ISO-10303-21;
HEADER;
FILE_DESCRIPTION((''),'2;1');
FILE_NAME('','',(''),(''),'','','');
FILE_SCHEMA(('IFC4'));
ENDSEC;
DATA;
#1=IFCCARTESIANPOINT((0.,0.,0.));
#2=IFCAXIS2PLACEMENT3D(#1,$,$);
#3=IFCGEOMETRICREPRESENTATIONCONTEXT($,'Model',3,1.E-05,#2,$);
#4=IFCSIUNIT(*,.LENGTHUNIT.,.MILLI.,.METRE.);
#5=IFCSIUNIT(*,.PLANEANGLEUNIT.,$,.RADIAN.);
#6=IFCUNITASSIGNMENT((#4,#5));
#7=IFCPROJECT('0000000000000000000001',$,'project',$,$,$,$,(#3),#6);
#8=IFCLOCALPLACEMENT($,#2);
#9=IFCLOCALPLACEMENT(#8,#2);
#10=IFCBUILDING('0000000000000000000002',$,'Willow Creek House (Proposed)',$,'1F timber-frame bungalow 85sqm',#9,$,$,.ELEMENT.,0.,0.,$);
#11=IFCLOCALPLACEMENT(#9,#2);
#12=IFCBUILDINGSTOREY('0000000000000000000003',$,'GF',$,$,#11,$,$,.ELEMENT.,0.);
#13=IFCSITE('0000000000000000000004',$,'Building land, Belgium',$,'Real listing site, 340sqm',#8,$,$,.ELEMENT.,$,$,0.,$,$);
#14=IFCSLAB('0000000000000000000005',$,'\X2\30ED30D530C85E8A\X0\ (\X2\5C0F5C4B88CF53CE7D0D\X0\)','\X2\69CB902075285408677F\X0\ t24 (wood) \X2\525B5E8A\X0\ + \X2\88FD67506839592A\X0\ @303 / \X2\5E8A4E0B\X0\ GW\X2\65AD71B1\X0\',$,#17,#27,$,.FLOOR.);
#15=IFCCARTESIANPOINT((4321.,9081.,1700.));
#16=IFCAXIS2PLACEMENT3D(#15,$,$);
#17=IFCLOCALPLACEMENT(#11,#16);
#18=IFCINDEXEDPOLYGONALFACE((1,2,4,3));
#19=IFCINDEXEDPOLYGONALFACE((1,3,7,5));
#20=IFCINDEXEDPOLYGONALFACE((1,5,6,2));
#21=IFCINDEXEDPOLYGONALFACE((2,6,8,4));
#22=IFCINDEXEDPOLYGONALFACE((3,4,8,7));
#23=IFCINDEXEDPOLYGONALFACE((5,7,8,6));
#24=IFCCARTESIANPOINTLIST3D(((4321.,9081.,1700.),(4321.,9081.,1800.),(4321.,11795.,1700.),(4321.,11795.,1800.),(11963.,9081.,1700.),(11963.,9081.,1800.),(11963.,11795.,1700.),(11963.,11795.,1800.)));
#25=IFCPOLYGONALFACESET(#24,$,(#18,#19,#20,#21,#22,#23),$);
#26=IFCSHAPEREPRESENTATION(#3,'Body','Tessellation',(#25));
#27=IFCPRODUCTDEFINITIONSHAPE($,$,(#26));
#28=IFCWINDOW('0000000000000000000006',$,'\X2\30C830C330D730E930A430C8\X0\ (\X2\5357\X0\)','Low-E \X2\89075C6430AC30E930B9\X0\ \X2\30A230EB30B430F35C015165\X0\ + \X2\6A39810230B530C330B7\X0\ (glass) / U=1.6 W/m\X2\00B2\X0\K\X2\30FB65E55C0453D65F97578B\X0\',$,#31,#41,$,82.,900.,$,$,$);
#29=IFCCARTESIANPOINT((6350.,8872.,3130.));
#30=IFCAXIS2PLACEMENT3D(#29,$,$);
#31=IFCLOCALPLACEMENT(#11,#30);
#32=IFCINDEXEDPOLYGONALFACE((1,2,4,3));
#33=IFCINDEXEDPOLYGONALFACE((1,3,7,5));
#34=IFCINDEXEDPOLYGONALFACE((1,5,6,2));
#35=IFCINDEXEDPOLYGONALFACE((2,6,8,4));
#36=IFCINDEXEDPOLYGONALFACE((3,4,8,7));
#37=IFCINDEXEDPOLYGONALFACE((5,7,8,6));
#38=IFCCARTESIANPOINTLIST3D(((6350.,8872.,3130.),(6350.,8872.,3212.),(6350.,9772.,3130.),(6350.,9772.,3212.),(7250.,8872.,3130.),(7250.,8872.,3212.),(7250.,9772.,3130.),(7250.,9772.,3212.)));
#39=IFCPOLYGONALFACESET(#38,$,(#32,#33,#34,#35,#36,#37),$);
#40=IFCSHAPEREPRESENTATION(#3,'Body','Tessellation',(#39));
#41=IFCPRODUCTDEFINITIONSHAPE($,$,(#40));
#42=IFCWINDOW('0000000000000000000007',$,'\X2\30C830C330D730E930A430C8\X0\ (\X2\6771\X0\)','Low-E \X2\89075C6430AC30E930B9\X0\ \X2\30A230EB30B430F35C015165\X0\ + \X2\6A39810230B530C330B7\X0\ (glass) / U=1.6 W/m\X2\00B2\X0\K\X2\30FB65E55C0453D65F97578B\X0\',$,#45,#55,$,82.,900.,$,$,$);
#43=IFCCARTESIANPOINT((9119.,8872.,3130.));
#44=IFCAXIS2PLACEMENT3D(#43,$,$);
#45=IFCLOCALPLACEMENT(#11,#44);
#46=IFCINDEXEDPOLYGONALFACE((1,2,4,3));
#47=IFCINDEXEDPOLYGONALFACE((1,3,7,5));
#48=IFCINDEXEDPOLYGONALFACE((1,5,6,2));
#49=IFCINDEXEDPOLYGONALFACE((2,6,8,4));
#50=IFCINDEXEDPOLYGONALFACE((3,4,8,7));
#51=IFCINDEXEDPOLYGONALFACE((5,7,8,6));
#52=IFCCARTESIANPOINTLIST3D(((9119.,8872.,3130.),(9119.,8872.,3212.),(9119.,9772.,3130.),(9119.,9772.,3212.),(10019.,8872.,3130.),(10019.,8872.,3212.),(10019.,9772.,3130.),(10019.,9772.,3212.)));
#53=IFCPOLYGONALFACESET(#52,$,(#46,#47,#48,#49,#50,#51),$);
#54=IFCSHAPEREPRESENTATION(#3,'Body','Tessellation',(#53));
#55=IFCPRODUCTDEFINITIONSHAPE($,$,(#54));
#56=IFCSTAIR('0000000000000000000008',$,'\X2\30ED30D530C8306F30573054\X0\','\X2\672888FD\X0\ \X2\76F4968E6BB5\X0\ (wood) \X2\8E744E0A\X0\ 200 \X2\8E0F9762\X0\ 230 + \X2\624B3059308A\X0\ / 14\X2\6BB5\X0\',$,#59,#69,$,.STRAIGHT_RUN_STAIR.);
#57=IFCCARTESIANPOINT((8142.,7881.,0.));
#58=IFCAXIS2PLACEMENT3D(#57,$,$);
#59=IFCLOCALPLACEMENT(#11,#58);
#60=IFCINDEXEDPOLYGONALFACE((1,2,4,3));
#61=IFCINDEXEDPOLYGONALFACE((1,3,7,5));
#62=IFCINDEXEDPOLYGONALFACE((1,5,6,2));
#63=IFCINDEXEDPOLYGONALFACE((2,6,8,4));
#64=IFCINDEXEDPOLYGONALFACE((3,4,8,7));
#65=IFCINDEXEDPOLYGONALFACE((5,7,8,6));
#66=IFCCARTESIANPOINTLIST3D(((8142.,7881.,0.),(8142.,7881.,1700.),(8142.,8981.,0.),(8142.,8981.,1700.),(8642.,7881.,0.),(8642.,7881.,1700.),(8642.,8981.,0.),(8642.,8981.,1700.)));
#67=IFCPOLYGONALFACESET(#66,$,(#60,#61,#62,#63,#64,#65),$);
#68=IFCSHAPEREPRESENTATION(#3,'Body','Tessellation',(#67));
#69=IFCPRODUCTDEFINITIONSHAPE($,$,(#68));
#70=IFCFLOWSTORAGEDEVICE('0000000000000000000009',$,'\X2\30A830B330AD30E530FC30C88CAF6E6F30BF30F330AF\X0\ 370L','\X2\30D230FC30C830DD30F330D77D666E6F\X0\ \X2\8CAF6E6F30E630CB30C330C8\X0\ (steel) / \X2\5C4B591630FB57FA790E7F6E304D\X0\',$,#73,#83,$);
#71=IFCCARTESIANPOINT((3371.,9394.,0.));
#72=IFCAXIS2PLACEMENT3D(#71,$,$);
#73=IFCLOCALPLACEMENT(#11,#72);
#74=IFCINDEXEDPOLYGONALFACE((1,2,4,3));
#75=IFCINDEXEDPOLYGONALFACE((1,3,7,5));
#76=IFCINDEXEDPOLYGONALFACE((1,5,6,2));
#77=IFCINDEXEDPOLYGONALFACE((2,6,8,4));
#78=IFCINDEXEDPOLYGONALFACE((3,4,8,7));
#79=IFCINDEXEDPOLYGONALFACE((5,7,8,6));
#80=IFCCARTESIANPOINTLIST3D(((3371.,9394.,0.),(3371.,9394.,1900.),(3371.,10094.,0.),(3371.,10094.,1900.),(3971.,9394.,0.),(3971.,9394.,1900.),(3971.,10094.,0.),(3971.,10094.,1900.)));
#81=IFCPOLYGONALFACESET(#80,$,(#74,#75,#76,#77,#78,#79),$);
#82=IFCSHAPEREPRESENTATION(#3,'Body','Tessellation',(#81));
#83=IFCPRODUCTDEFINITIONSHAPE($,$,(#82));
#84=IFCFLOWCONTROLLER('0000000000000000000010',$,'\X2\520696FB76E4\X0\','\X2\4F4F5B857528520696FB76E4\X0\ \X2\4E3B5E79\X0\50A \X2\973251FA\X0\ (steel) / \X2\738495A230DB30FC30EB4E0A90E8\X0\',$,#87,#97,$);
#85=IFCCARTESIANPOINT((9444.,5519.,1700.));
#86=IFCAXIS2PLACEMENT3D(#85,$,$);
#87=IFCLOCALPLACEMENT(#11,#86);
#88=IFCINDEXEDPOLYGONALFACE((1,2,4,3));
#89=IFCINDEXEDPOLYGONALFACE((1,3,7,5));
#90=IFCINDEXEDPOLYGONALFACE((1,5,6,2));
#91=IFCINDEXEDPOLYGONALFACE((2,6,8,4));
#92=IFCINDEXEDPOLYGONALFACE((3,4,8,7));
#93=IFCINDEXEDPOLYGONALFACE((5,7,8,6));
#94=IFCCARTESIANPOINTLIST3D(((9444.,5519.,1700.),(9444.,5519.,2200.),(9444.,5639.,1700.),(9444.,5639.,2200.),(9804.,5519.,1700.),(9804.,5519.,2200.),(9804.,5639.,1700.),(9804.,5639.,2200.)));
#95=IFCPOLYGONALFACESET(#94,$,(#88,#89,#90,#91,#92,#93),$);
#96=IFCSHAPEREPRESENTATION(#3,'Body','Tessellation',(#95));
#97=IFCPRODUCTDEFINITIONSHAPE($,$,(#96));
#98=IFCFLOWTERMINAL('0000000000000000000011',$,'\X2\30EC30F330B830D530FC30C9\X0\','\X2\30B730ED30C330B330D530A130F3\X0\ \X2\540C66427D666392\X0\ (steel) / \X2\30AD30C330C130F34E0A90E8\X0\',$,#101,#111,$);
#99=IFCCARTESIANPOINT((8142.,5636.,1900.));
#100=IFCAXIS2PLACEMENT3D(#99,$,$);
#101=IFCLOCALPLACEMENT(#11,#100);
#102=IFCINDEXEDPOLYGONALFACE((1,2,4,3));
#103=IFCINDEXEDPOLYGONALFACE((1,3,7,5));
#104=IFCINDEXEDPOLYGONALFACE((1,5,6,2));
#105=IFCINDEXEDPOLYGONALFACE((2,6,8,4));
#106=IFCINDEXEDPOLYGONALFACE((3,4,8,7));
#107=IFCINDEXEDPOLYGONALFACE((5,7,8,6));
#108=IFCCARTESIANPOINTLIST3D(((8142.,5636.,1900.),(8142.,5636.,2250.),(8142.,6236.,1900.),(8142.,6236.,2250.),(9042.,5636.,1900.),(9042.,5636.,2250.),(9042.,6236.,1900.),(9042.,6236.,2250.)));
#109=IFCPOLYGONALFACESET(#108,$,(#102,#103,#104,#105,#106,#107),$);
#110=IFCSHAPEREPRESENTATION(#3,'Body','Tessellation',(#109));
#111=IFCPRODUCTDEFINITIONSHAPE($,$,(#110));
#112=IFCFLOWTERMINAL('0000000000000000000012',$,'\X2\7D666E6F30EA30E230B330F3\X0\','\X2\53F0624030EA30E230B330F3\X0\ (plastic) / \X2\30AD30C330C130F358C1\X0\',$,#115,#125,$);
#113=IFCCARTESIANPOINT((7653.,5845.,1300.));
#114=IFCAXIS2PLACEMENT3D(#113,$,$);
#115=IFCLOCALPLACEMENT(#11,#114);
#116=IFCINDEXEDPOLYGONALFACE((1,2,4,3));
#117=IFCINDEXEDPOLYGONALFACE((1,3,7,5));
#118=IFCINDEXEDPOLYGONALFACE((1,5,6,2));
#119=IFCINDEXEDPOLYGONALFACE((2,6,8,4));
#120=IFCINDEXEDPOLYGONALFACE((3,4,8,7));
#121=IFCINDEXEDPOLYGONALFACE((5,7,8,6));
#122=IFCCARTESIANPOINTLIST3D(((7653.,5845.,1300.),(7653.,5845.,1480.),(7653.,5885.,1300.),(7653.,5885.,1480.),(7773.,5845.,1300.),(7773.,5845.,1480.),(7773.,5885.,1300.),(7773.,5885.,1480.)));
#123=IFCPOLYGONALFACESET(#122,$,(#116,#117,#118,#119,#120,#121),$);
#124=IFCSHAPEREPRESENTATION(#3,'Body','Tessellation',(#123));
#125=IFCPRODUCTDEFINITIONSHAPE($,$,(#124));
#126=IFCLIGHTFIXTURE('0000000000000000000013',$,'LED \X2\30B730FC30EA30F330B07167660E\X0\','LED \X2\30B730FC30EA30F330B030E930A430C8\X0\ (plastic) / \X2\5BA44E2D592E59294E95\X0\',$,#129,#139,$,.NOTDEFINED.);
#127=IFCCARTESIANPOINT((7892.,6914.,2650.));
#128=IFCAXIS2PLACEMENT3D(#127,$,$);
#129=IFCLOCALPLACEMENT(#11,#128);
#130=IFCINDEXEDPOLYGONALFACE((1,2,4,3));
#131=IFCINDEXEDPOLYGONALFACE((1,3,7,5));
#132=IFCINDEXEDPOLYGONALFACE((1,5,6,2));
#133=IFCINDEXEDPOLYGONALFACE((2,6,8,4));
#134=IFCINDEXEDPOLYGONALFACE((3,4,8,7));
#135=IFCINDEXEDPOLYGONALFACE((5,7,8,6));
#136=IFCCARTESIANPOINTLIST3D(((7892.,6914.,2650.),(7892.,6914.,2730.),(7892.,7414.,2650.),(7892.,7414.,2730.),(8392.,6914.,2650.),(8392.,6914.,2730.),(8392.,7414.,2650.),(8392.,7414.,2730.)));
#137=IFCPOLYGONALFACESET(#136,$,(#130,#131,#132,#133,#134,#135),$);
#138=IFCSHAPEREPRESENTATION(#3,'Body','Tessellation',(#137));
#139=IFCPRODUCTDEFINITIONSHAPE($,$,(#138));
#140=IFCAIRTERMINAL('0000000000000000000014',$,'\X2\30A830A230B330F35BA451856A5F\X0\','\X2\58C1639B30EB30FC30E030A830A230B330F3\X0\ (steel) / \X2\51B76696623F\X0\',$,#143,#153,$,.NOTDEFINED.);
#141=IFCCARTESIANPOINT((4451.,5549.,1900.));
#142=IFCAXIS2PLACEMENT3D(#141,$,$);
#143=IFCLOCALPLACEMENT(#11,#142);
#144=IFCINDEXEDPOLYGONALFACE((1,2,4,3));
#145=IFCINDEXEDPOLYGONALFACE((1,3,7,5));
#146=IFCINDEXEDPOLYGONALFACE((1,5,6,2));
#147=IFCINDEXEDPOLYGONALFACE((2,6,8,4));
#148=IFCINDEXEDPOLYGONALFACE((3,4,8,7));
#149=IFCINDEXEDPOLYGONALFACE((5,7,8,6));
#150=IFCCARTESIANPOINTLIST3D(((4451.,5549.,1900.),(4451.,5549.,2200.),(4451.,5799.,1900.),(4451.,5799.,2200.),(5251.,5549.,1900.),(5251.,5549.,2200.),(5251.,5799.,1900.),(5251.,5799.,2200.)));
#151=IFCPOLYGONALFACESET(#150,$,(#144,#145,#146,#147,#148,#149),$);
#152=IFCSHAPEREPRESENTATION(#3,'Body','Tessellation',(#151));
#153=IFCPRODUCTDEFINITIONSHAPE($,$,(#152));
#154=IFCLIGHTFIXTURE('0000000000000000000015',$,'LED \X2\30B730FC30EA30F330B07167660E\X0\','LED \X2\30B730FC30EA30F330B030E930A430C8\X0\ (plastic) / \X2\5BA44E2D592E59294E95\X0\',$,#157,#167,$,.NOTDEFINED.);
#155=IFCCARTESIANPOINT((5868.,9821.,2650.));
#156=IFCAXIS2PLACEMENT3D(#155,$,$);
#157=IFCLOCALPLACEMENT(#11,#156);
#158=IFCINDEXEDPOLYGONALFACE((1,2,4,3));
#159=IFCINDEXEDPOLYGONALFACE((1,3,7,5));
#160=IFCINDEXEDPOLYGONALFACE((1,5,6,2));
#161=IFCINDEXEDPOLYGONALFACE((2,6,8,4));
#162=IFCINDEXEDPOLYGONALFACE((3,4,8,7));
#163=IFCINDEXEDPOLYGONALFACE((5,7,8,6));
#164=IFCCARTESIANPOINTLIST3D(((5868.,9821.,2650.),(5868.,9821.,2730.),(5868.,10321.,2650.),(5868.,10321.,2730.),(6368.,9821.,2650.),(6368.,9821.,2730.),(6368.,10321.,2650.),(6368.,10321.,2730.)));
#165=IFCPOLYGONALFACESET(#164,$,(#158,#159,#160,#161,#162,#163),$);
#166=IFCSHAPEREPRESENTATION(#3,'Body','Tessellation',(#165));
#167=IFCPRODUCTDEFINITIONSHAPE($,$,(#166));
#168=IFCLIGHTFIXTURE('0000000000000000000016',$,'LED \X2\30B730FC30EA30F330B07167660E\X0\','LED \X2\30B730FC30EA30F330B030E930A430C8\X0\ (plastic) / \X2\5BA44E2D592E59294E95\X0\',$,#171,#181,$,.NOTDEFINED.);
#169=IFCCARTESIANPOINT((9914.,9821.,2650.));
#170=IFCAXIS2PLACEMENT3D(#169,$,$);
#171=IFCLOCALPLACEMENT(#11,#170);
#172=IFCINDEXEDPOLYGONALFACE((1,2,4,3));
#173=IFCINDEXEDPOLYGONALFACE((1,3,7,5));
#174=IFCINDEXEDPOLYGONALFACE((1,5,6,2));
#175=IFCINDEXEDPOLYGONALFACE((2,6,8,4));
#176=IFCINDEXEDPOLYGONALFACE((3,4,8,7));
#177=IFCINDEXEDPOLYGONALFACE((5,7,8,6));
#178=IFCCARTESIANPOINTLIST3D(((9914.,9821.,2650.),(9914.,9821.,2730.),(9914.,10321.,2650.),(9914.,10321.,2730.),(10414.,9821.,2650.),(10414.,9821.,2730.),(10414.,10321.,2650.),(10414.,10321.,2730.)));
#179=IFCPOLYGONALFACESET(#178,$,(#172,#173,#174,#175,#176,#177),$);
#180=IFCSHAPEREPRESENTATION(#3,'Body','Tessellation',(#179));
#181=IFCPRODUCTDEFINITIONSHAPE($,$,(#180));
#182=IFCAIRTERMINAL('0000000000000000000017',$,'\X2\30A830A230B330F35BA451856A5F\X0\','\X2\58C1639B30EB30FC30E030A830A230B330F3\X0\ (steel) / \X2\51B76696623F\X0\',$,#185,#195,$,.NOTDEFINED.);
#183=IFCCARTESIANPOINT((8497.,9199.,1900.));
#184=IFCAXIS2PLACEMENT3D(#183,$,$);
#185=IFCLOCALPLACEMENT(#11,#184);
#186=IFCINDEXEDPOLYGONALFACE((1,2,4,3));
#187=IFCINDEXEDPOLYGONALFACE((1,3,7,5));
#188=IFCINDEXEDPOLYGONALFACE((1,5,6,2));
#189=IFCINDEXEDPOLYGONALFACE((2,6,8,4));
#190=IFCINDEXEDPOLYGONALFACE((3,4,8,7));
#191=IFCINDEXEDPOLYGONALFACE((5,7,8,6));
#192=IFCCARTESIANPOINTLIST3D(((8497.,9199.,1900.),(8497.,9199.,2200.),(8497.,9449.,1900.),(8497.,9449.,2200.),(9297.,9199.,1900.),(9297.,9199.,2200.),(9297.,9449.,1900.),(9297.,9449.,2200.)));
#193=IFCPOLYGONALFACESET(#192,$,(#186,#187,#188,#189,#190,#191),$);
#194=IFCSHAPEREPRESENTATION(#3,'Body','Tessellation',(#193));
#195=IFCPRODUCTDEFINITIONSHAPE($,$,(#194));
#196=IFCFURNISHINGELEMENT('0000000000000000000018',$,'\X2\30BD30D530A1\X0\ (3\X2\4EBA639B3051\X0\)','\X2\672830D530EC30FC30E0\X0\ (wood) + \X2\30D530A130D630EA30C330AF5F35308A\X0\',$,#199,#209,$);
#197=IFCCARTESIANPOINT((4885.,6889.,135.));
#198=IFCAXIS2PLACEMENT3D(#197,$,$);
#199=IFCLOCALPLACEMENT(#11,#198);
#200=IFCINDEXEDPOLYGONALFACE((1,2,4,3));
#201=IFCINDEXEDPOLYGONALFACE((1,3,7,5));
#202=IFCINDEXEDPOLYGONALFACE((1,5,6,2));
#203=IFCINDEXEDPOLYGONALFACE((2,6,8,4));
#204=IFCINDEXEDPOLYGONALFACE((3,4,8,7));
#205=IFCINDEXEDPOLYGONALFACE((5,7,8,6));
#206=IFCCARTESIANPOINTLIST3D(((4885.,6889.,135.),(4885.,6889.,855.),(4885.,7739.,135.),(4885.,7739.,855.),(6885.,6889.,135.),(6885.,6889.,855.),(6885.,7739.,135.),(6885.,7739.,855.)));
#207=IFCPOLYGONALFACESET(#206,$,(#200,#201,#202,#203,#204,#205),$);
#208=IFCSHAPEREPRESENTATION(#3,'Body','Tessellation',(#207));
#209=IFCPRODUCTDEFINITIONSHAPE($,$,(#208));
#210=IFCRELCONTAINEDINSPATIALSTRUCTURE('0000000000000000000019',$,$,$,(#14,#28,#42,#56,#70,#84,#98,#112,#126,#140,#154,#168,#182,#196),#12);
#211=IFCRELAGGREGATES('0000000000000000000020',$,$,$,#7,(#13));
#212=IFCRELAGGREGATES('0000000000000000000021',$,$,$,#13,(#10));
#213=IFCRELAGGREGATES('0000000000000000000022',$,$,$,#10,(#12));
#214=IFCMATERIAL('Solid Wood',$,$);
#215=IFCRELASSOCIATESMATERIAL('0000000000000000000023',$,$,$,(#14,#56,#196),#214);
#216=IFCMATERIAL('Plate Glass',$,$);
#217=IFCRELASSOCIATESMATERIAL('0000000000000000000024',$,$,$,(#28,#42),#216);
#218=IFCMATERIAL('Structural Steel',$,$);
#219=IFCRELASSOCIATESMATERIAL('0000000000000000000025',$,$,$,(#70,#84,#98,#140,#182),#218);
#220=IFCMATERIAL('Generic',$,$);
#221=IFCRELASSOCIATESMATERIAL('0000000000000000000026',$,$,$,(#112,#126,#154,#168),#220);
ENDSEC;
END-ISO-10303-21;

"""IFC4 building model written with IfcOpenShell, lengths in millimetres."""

from ifc_helpers import new_model, si_unit, frame, frame_2d, origin, place, context, project, spatial, rectangle, extrude, material, element, save


model = new_model("IFC4")

# Units and contexts
model_context = context("Model", 3, precision=1e-05, world=origin())
ifc_project = project(units=[si_unit("LENGTHUNIT", "METRE", prefix="MILLI"), si_unit("PLANEANGLEUNIT", "RADIAN")], contexts=[model_context])

# Site, building, storey
site_placement = place(None, origin())
site = spatial("IfcSite", under=ifc_project, at=site_placement, Name="Building land, Belgium", ObjectType="Real listing site, 340sqm", CompositionType="ELEMENT", RefElevation=0.0)
building_placement = place(site_placement, origin())
building = spatial("IfcBuilding", under=site, at=building_placement, Name="Willow Creek House (Proposed)", ObjectType="1F timber-frame bungalow 85sqm", CompositionType="ELEMENT", ElevationOfRefHeight=0.0, ElevationOfTerrain=0.0)
storey_placement = place(building_placement, origin())
storey = spatial("IfcBuildingStorey", under=building, at=storey_placement, Name="GF", CompositionType="ELEMENT", Elevation=0.0)

# Shared definitions
ifc_material_1 = material(Name="Solid Wood")

# Slab
slab_placement = place(storey_placement, frame((4321.0, 9081.0, 1700.0)))
element("IfcSlab", 1, at=slab_placement, inside=storey, material=ifc_material_1, Name="ロフト床 (小屋裏収納)", Description="構造用合板 t24 (wood) 剛床 + 製材根太 @303 / 床下 GW断熱", PredefinedType="FLOOR", context=model_context, shape_type="SweptSolid", body=[
    extrude(rectangle(XDim=7642.0, YDim=2714.0, at=frame_2d((3821.0, 1357.0))), frame((4321.0, 9081.0, 1700.0)), (0.0, 0.0, 1.0), 100.0),
])

# Windows
ifc_material_2 = material(Name="Plate Glass")
window_1_placement = place(storey_placement, frame((6350.0, 8872.0, 3130.0)))
element("IfcWindow", 2, at=window_1_placement, inside=storey, material=ifc_material_2, Name="トップライト (南)", Description="Low-E 複層ガラス アルゴン封入 + 樹脂サッシ (glass) / U=1.6 W/m²K・日射取得型", OverallHeight=82.0, OverallWidth=900.0, context=model_context, shape_type="SweptSolid", body=[
    extrude(rectangle(XDim=900.0, YDim=900.0, at=frame_2d((450.0, 450.0))), frame((6350.0, 8872.0, 3130.0)), (0.0, 0.0, 1.0), 82.0),
])
window_2_placement = place(storey_placement, frame((9119.0, 8872.0, 3130.0)))
element("IfcWindow", 3, at=window_2_placement, inside=storey, material=ifc_material_2, Name="トップライト (東)", Description="Low-E 複層ガラス アルゴン封入 + 樹脂サッシ (glass) / U=1.6 W/m²K・日射取得型", OverallHeight=82.0, OverallWidth=900.0, context=model_context, shape_type="SweptSolid", body=[
    extrude(rectangle(XDim=900.0, YDim=900.0, at=frame_2d((450.0, 450.0))), frame((9119.0, 8872.0, 3130.0)), (0.0, 0.0, 1.0), 82.0),
])

# Stair
stair_placement = place(storey_placement, frame((8142.0, 7881.0, 0.0)))
element("IfcStair", 4, at=stair_placement, inside=storey, material=ifc_material_1, Name="ロフトはしご", Description="木製 直階段 (wood) 蹴上 200 踏面 230 + 手すり / 14段", PredefinedType="STRAIGHT_RUN_STAIR", context=model_context, shape_type="SweptSolid", body=[
    extrude(rectangle(XDim=500.0, YDim=1100.0, at=frame_2d((250.0, 550.0))), frame((8142.0, 7881.0, 0.0)), (0.0, 0.0, 1.0), 1700.0),
])

# Flow storage device
ifc_material_3 = material(Name="Structural Steel")
flow_storage_device_placement = place(storey_placement, frame((3371.0, 9394.0, 0.0)))
element("IfcFlowStorageDevice", 5, at=flow_storage_device_placement, inside=storey, material=ifc_material_3, Name="エコキュート貯湯タンク 370L", Description="ヒートポンプ給湯 貯湯ユニット (steel) / 屋外・基礎置き", context=model_context, shape_type="SweptSolid", body=[
    extrude(rectangle(XDim=600.0, YDim=700.0, at=frame_2d((300.0, 350.0))), frame((3371.0, 9394.0, 0.0)), (0.0, 0.0, 1.0), 1900.0),
])

# Flow controller
flow_controller_placement = place(storey_placement, frame((9444.0, 5519.0, 1700.0)))
element("IfcFlowController", 6, at=flow_controller_placement, inside=storey, material=ifc_material_3, Name="分電盤", Description="住宅用分電盤 主幹50A 露出 (steel) / 玄関ホール上部", context=model_context, shape_type="SweptSolid", body=[
    extrude(rectangle(XDim=360.0, YDim=120.0, at=frame_2d((180.0, 60.0))), frame((9444.0, 5519.0, 1700.0)), (0.0, 0.0, 1.0), 500.0),
])

# Flow terminals
flow_terminal_1_placement = place(storey_placement, frame((8142.0, 5636.0, 1900.0)))
element("IfcFlowTerminal", 7, at=flow_terminal_1_placement, inside=storey, material=ifc_material_3, Name="レンジフード", Description="シロッコファン 同時給排 (steel) / キッチン上部", context=model_context, shape_type="SweptSolid", body=[
    extrude(rectangle(XDim=900.0, YDim=600.0, at=frame_2d((450.0, 300.0))), frame((8142.0, 5636.0, 1900.0)), (0.0, 0.0, 1.0), 350.0),
])
ifc_material_4 = material(Name="Generic")
flow_terminal_2_placement = place(storey_placement, frame((7653.0, 5845.0, 1300.0)))
element("IfcFlowTerminal", 8, at=flow_terminal_2_placement, inside=storey, material=ifc_material_4, Name="給湯リモコン", Description="台所リモコン (plastic) / キッチン壁", context=model_context, shape_type="SweptSolid", body=[
    extrude(rectangle(XDim=120.0, YDim=40.0, at=frame_2d((60.0, 20.0))), frame((7653.0, 5845.0, 1300.0)), (0.0, 0.0, 1.0), 180.0),
])

# Light fixture
light_fixture_1_placement = place(storey_placement, frame((7892.0, 6914.0, 2650.0)))
element("IfcLightFixture", 9, at=light_fixture_1_placement, inside=storey, material=ifc_material_4, Name="LED シーリング照明", Description="LED シーリングライト (plastic) / 室中央天井", PredefinedType="NOTDEFINED", context=model_context, shape_type="SweptSolid", body=[
    extrude(rectangle(XDim=500.0, YDim=500.0, at=frame_2d((250.0, 250.0))), frame((7892.0, 6914.0, 2650.0)), (0.0, 0.0, 1.0), 80.0),
])

# Air terminal
air_terminal_1_placement = place(storey_placement, frame((4451.0, 5549.0, 1900.0)))
element("IfcAirTerminal", 10, at=air_terminal_1_placement, inside=storey, material=ifc_material_3, Name="エアコン室内機", Description="壁掛ルームエアコン (steel) / 冷暖房", PredefinedType="NOTDEFINED", context=model_context, shape_type="SweptSolid", body=[
    extrude(rectangle(XDim=800.0, YDim=250.0, at=frame_2d((400.0, 125.0))), frame((4451.0, 5549.0, 1900.0)), (0.0, 0.0, 1.0), 300.0),
])

# Light fixtures
light_fixture_2_placement = place(storey_placement, frame((5868.0, 9821.0, 2650.0)))
element("IfcLightFixture", 11, at=light_fixture_2_placement, inside=storey, material=ifc_material_4, Name="LED シーリング照明", Description="LED シーリングライト (plastic) / 室中央天井", PredefinedType="NOTDEFINED", context=model_context, shape_type="SweptSolid", body=[
    extrude(rectangle(XDim=500.0, YDim=500.0, at=frame_2d((250.0, 250.0))), frame((5868.0, 9821.0, 2650.0)), (0.0, 0.0, 1.0), 80.0),
])
light_fixture_3_placement = place(storey_placement, frame((9914.0, 9821.0, 2650.0)))
element("IfcLightFixture", 12, at=light_fixture_3_placement, inside=storey, material=ifc_material_4, Name="LED シーリング照明", Description="LED シーリングライト (plastic) / 室中央天井", PredefinedType="NOTDEFINED", context=model_context, shape_type="SweptSolid", body=[
    extrude(rectangle(XDim=500.0, YDim=500.0, at=frame_2d((250.0, 250.0))), frame((9914.0, 9821.0, 2650.0)), (0.0, 0.0, 1.0), 80.0),
])

# Air terminal
air_terminal_2_placement = place(storey_placement, frame((8497.0, 9199.0, 1900.0)))
element("IfcAirTerminal", 13, at=air_terminal_2_placement, inside=storey, material=ifc_material_3, Name="エアコン室内機", Description="壁掛ルームエアコン (steel) / 冷暖房", PredefinedType="NOTDEFINED", context=model_context, shape_type="SweptSolid", body=[
    extrude(rectangle(XDim=800.0, YDim=250.0, at=frame_2d((400.0, 125.0))), frame((8497.0, 9199.0, 1900.0)), (0.0, 0.0, 1.0), 300.0),
])

# Furnishing element
furnishing_1_placement = place(storey_placement, frame((4885.0, 6889.0, 135.0)))
element("IfcFurnishingElement", 14, at=furnishing_1_placement, inside=storey, material=ifc_material_1, Name="ソファ (3人掛け)", Description="木フレーム (wood) + ファブリック張り", context=model_context, shape_type="SweptSolid", body=[
    extrude(rectangle(XDim=2000.0, YDim=850.0, at=frame_2d((1000.0, 425.0))), frame((4885.0, 6889.0, 135.0)), (0.0, 0.0, 1.0), 720.0),
])

save(model, "model.ifc")
